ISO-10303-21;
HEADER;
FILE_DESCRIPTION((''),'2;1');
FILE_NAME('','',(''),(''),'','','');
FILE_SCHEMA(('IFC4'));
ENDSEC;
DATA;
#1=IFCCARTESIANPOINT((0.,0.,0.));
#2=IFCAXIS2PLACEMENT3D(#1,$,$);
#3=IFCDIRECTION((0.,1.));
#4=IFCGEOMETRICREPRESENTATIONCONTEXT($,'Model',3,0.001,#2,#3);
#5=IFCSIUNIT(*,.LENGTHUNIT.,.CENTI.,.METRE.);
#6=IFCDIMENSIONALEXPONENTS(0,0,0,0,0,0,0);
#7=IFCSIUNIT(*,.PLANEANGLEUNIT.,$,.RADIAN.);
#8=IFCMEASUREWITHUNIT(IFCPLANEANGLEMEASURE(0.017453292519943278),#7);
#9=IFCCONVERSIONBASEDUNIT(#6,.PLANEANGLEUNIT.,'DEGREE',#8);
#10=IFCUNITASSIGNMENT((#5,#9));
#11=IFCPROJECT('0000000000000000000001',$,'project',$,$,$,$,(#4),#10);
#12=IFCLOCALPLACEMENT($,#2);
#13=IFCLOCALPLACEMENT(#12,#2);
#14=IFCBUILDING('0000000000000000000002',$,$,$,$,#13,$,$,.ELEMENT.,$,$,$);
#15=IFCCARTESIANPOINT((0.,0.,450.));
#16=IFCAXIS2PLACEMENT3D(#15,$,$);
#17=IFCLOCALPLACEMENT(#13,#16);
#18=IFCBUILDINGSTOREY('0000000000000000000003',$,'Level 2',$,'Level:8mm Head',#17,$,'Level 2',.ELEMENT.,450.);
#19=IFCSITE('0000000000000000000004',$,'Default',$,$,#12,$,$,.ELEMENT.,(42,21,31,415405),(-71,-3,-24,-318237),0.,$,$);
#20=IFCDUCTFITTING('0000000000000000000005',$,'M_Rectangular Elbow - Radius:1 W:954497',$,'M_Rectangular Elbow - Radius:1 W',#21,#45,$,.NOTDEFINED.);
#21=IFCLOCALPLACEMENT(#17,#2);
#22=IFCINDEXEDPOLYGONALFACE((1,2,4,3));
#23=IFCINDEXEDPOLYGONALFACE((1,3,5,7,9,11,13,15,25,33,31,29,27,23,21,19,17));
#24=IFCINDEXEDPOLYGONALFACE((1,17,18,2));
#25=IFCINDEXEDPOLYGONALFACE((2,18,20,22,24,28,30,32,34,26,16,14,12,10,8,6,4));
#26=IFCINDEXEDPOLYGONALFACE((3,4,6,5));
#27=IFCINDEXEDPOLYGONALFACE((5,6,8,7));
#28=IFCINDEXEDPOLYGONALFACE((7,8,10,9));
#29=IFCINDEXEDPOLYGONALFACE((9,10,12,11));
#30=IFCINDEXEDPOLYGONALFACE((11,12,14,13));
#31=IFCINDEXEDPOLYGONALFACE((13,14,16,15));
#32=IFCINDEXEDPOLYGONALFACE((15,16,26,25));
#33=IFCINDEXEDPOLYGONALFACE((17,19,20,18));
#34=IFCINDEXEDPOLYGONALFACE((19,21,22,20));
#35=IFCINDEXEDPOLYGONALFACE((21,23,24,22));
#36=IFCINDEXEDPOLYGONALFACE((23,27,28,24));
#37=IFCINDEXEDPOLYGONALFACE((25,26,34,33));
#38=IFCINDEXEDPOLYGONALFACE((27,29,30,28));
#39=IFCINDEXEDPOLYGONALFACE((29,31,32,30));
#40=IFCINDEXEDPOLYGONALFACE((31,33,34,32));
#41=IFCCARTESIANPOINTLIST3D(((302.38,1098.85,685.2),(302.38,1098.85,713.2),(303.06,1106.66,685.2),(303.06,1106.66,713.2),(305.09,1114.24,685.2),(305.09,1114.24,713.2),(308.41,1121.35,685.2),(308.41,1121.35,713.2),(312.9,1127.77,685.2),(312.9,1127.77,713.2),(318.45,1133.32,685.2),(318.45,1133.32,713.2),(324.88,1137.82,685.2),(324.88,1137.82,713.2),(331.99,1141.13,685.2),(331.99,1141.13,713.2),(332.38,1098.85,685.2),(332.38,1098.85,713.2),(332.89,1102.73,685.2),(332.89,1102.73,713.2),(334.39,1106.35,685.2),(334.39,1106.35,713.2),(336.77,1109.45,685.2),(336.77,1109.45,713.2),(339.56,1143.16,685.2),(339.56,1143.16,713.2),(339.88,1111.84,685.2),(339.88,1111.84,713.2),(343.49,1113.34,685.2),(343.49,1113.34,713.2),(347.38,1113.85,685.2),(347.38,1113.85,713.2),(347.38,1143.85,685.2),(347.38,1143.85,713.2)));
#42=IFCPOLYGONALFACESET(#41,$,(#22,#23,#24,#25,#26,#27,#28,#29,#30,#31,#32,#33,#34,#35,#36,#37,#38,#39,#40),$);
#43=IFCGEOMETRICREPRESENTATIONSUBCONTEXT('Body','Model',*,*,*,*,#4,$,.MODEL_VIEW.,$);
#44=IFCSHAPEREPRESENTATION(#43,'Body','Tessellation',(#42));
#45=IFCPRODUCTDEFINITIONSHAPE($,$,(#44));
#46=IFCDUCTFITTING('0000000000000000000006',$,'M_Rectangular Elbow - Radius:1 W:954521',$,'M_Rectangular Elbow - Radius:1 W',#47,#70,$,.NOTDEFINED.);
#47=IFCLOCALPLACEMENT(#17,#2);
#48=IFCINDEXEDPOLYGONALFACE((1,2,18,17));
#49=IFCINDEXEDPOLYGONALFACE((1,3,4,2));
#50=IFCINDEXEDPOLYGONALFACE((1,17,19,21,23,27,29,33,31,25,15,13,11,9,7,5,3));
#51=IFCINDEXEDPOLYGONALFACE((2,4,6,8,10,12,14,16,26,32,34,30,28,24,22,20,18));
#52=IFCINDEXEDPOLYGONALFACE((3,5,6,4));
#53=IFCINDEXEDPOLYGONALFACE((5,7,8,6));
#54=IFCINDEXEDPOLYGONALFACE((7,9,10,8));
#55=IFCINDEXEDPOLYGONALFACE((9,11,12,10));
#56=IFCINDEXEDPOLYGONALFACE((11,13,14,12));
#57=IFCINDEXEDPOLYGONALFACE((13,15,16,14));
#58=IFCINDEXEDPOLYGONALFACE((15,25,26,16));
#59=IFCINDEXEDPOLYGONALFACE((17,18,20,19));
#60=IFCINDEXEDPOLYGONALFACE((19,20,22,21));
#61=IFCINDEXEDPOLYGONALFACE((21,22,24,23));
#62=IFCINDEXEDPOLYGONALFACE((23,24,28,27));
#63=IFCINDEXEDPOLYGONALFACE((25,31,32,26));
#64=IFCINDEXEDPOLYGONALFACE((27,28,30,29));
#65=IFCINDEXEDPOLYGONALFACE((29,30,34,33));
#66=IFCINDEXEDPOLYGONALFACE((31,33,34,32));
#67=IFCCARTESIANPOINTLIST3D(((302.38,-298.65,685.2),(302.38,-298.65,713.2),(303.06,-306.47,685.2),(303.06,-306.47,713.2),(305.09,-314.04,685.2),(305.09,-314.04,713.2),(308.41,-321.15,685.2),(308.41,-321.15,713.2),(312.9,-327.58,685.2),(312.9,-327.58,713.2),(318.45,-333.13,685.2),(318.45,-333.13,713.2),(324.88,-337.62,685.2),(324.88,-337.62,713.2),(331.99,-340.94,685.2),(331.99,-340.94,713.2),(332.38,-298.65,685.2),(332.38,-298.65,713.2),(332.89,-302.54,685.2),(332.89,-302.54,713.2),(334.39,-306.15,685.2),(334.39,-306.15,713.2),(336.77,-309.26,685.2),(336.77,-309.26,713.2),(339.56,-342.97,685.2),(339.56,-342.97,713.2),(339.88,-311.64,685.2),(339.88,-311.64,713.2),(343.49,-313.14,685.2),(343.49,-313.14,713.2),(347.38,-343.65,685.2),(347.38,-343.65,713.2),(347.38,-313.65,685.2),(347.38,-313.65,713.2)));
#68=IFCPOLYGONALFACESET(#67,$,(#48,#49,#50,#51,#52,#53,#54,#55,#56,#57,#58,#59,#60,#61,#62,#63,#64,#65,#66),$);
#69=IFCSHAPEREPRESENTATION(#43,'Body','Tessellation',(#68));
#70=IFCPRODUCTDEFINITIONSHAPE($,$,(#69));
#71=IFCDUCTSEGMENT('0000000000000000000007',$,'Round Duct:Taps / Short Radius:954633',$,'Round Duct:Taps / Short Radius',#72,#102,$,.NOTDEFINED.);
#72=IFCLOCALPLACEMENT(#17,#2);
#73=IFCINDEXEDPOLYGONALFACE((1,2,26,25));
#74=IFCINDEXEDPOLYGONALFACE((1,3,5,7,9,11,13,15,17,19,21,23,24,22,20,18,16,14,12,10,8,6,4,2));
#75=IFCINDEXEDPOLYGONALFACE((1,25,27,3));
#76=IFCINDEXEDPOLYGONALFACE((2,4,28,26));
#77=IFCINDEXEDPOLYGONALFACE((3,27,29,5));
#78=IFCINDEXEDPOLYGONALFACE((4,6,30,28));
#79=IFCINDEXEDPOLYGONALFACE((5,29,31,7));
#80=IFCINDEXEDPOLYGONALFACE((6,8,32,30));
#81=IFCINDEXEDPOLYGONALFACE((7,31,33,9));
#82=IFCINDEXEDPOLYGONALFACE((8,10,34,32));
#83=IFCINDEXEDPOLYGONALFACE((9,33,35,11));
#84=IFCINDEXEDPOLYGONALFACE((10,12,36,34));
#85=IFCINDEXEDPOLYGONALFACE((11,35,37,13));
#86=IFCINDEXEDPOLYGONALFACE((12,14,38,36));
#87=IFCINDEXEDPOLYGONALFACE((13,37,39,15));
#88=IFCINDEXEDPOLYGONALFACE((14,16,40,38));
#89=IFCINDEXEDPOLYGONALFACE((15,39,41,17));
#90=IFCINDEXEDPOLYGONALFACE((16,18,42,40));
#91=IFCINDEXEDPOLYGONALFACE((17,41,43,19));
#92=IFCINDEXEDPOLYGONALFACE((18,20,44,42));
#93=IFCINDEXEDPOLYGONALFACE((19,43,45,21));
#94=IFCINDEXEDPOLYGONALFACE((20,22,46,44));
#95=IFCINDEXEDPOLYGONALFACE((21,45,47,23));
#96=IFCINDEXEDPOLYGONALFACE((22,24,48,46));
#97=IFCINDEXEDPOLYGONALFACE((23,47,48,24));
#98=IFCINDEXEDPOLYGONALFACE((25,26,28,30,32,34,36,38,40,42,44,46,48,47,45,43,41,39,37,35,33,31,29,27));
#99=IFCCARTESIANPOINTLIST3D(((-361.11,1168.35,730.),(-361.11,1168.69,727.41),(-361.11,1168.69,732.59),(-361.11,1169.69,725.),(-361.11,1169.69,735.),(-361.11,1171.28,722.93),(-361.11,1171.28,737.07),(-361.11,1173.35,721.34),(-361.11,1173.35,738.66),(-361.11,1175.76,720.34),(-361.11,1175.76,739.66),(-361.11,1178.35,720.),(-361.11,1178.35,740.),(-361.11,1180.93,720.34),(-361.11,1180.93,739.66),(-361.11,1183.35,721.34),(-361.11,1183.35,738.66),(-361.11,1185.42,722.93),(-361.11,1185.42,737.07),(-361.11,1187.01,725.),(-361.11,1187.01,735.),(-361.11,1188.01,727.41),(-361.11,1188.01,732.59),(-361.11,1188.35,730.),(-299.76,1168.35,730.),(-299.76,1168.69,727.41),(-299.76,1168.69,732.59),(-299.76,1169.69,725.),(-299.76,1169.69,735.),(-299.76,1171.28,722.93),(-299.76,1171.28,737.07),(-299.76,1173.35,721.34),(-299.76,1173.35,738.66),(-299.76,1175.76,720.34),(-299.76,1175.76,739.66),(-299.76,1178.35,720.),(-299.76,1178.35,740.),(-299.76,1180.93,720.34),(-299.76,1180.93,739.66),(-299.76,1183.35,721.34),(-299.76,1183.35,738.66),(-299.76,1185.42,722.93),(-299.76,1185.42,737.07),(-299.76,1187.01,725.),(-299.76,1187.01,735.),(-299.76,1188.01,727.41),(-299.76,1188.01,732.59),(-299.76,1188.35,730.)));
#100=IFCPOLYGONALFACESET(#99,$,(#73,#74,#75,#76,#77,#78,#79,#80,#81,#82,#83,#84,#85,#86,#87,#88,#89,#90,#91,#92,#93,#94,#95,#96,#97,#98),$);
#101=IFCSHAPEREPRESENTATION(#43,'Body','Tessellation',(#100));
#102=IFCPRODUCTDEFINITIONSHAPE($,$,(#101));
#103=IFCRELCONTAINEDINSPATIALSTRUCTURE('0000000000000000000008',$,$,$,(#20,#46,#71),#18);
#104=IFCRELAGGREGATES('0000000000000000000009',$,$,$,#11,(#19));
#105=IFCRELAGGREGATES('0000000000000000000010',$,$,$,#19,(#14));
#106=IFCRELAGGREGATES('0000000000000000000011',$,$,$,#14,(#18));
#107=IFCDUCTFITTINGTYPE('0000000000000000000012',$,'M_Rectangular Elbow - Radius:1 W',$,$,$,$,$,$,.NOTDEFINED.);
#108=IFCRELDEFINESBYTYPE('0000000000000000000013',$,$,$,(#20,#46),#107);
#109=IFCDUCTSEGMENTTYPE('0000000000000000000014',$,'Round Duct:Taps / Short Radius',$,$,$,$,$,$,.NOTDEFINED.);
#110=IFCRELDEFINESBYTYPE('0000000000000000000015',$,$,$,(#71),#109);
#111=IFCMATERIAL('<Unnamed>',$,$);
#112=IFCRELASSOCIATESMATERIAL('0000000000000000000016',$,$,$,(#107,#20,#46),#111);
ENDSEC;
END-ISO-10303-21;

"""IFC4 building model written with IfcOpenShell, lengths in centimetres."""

from ifc_helpers import new_model, entity, si_unit, converted_unit, direction, frame, origin, place, context, subcontext, project, spatial, line, arc, indexed_curve, outline, extrude, source, transform, mapped, material, type_object, type_shapes, element, save


model = new_model("IFC4")

# Units and contexts
model_context = context("Model", 3, precision=0.001, world=origin(), true_north=direction((0.0, 1.0)))
body_context = subcontext(model_context, "Body", "Model", "MODEL_VIEW")
ifc_project = project(units=[si_unit("LENGTHUNIT", "METRE", prefix="CENTI"), converted_unit("PLANEANGLEUNIT", "DEGREE", entity("IfcPlaneAngleMeasure", 0.017453292519943278), si_unit("PLANEANGLEUNIT", "RADIAN"), dimensions=[0, 0, 0, 0, 0, 0, 0])], contexts=[model_context])

# Site, building, storey
site_placement = place(None, origin())
site = spatial("IfcSite", under=ifc_project, at=site_placement, Name="Default", CompositionType="ELEMENT", RefLatitude=(42, 21, 31, 415405), RefLongitude=(-71, -3, -24, -318237), RefElevation=0.0)
building_placement = place(site_placement, origin())
building = spatial("IfcBuilding", under=site, at=building_placement, CompositionType="ELEMENT")
storey_placement = place(building_placement, frame((0.0, 0.0, 450.0)))
storey = spatial("IfcBuildingStorey", under=building, at=storey_placement, Name="Level 2", ObjectType="Level:8mm Head", LongName="Level 2", CompositionType="ELEMENT", Elevation=450.0)

# Duct fittings
ifc_material = material(Name="<Unnamed>")
duct_fitting_type_1 = type_object("IfcDuctFittingType", Name="M_Rectangular Elbow - Radius:1 W", PredefinedType="NOTDEFINED", material=ifc_material)
shared_shape_1 = source(origin(), body_context, "Body", "SweptSolid", [
    extrude(outline(indexed_curve([(-15.0, -30.0), (16.82, -16.82), (30.0, 15.0), (0.0, 15.0), (-4.39, 4.39), (-15.0, 0.0)], segments=[arc(1, 2, 3), line(3, 4), arc(4, 5, 6), line(6, 1)], self_intersect=False)), frame((-15.0, -15.0, -14.0), z_axis=(0.0, 0.0, 1.0), x_axis=(0.0, 1.0, 0.0)), (0.0, 0.0, 1.0), 28.0),
])
type_shapes(duct_fitting_type_1, [shared_shape_1])
for number, where, z_axis, x_axis, name in (
    (1, (317.38, 1128.85, 699.2), (0.0, 0.0, 1.0), (0.0, 1.0, 0.0), "M_Rectangular Elbow - Radius:1 W:954497"),
    (2, (317.38, -328.65, 699.2), (0.0, 0.0, 1.0), (-1.0, 0.0, 0.0), "M_Rectangular Elbow - Radius:1 W:954521"),
):
    element("IfcDuctFitting", number, at=place(storey_placement, frame(where, z_axis=z_axis, x_axis=x_axis)), inside=storey, type_object=duct_fitting_type_1, material=ifc_material, Name=name, ObjectType="M_Rectangular Elbow - Radius:1 W", PredefinedType="NOTDEFINED", context=body_context, shape_type="MappedRepresentation", body=[
        mapped(shared_shape_1, transform((0.0, 0.0, 0.0), scale=1.0)),
    ])

# Duct segment
duct_segment_type_1 = type_object("IfcDuctSegmentType", Name="Round Duct:Taps / Short Radius", PredefinedType="NOTDEFINED")
duct_segment_1_placement = place(storey_placement, origin())
element("IfcDuctSegment", 3, at=duct_segment_1_placement, inside=storey, type_object=duct_segment_type_1, Name="Round Duct:Taps / Short Radius:954633", ObjectType="Round Duct:Taps / Short Radius", PredefinedType="NOTDEFINED", context=body_context, shape_type="SweptSolid", body=[
    extrude(outline(indexed_curve([(10.0, 0.0), (7.07, 7.07), (0.0, 10.0), (-7.07, 7.07), (-10.0, 0.0), (-7.07, -7.07), (0.0, -10.0), (7.07, -7.07)], segments=[arc(1, 2, 3), arc(3, 4, 5), arc(5, 6, 7), arc(7, 8, 1)], self_intersect=False)), frame((-361.11, 1178.35, 730.0), z_axis=(1.0, 0.0, 0.0), x_axis=(0.0, 1.0, 0.0)), (0.0, 0.0, 1.0), 61.35),
])

save(model, "model.ifc")
